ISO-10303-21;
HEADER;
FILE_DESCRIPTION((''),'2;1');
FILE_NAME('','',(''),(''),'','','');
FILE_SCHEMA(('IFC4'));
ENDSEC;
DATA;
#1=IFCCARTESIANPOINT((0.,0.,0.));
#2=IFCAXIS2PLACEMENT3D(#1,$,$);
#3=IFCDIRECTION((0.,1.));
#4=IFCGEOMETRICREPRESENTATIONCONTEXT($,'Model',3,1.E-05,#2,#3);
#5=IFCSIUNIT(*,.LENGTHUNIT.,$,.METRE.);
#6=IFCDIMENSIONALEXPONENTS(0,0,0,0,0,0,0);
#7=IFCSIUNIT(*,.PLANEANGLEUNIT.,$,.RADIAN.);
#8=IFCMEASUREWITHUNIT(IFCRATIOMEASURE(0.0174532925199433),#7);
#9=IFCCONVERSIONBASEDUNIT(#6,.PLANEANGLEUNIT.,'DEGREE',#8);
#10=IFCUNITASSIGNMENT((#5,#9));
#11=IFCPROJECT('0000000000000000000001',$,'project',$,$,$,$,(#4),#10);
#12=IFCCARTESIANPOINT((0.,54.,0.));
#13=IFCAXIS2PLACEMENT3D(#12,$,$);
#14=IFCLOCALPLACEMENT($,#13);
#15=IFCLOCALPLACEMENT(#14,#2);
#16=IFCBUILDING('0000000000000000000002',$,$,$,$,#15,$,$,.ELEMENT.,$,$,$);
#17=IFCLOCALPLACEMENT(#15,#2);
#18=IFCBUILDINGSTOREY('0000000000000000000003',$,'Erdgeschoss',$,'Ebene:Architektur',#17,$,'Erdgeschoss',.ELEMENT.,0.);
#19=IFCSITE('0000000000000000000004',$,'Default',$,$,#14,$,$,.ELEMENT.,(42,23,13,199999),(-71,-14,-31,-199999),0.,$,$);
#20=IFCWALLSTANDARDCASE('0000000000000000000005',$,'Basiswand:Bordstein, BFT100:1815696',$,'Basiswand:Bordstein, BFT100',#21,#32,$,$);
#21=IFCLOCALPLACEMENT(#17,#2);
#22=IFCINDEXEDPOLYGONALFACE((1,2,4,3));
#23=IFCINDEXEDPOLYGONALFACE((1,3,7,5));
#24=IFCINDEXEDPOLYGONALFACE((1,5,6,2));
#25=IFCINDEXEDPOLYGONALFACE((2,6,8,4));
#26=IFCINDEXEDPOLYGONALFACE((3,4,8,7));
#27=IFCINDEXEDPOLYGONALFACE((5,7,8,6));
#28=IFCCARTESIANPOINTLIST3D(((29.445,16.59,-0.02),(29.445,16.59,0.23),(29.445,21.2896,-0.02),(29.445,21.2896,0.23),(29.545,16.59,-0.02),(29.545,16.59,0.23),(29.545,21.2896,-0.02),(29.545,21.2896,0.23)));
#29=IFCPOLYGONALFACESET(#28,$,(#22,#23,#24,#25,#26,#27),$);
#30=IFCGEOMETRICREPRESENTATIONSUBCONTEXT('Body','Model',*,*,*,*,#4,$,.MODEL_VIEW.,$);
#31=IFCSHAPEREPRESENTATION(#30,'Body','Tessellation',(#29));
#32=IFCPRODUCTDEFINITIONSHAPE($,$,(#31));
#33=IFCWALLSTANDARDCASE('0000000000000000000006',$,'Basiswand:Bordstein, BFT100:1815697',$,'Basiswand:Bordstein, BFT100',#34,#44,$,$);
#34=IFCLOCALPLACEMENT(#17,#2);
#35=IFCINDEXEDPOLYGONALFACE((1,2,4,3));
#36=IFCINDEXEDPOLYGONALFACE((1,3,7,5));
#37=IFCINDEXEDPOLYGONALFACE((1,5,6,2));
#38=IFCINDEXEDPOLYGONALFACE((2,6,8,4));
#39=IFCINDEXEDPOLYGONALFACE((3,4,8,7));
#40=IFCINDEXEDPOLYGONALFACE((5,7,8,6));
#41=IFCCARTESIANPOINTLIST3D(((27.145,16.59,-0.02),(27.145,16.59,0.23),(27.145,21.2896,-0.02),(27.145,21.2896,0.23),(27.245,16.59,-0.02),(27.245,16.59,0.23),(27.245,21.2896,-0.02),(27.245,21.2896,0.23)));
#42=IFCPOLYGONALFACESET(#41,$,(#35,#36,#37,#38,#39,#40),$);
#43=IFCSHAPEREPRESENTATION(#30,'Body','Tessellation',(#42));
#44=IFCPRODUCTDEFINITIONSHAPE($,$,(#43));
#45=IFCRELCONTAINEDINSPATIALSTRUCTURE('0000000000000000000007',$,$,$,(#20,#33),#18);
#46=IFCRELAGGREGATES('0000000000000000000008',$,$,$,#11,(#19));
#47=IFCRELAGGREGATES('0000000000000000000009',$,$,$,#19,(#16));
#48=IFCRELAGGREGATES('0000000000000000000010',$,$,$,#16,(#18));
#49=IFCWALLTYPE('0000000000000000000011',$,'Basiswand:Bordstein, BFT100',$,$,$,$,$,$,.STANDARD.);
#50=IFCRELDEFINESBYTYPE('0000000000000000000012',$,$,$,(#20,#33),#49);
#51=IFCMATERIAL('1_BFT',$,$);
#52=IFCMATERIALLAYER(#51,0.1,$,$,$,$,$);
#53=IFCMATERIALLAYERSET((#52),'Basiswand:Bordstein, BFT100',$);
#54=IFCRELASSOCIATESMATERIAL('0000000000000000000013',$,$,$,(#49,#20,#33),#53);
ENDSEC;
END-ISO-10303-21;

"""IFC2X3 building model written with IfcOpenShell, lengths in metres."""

from ifc_helpers import new_model, entity, si_unit, converted_unit, direction, frame, frame_2d, origin, place, context, subcontext, project, spatial, rectangle, extrude, material, layer, layer_set, layer_usage, type_object, element, save


model = new_model("IFC2X3")

# Units and contexts
model_context = context("Model", 3, precision=1e-05, world=origin(), true_north=direction((0.0, 1.0)))
body_context = subcontext(model_context, "Body", "Model", "MODEL_VIEW")
ifc_project = project(units=[si_unit("LENGTHUNIT", "METRE"), converted_unit("PLANEANGLEUNIT", "DEGREE", entity("IfcRatioMeasure", 0.0174532925199433), si_unit("PLANEANGLEUNIT", "RADIAN"), dimensions=[0, 0, 0, 0, 0, 0, 0])], contexts=[model_context])

# Site, building, storey
site_placement = place(None, frame((0.0, 54.0, 0.0)))
site = spatial("IfcSite", under=ifc_project, at=site_placement, Name="Default", CompositionType="ELEMENT", RefLatitude=(42, 23, 13, 199999), RefLongitude=(-71, -14, -31, -199999), RefElevation=0.0)
building_placement = place(site_placement, origin())
building = spatial("IfcBuilding", under=site, at=building_placement, CompositionType="ELEMENT")
storey_placement = place(building_placement, origin())
storey = spatial("IfcBuildingStorey", under=building, at=storey_placement, Name="Erdgeschoss", ObjectType="Ebene:Architektur", LongName="Erdgeschoss", CompositionType="ELEMENT", Elevation=0.0)

# Shared definitions
ifc_material_1 = material(Name="1_BFT")

# Walls
ifc_layer_1 = layer(ifc_material_1, 0.1)
ifc_layer_set_1 = layer_set([ifc_layer_1], Name="Basiswand:Bordstein, BFT100")
ifc_layer_usage_1 = layer_usage(ifc_layer_set_1, "AXIS2", "NEGATIVE", 0.05)
wall_type_1 = type_object("IfcWallType", Name="Basiswand:Bordstein, BFT100", PredefinedType="STANDARD", material=ifc_layer_set_1)
wall_1_placement = place(storey_placement, frame((29.495, 21.2896, -0.02), z_axis=(0.0, 0.0, 1.0), x_axis=(0.0, -1.0, 0.0)))
element("IfcWallStandardCase", 1, at=wall_1_placement, inside=storey, type_object=wall_type_1, material=ifc_layer_usage_1, Name="Basiswand:Bordstein, BFT100:1815696", ObjectType="Basiswand:Bordstein, BFT100", context=body_context, shape_type="SweptSolid", body=[
    extrude(rectangle(XDim=4.6996, YDim=0.1, at=frame_2d((2.3498, 0.0), x_axis=(-1.0, 0.0))), origin(), (0.0, 0.0, 1.0), 0.25),
])
ifc_layer_usage_2 = layer_usage(ifc_layer_set_1, "AXIS2", "NEGATIVE", 0.05)
wall_2_placement = place(storey_placement, frame((27.195, 16.59, -0.02), z_axis=(0.0, 0.0, 1.0), x_axis=(0.0, 1.0, 0.0)))
element("IfcWallStandardCase", 2, at=wall_2_placement, inside=storey, type_object=wall_type_1, material=ifc_layer_usage_2, Name="Basiswand:Bordstein, BFT100:1815697", ObjectType="Basiswand:Bordstein, BFT100", context=body_context, shape_type="SweptSolid", body=[
    extrude(rectangle(XDim=4.6996, YDim=0.1, at=frame_2d((2.3498, 0.0), x_axis=(-1.0, 0.0))), origin(), (0.0, 0.0, 1.0), 0.25),
])

save(model, "model.ifc")
